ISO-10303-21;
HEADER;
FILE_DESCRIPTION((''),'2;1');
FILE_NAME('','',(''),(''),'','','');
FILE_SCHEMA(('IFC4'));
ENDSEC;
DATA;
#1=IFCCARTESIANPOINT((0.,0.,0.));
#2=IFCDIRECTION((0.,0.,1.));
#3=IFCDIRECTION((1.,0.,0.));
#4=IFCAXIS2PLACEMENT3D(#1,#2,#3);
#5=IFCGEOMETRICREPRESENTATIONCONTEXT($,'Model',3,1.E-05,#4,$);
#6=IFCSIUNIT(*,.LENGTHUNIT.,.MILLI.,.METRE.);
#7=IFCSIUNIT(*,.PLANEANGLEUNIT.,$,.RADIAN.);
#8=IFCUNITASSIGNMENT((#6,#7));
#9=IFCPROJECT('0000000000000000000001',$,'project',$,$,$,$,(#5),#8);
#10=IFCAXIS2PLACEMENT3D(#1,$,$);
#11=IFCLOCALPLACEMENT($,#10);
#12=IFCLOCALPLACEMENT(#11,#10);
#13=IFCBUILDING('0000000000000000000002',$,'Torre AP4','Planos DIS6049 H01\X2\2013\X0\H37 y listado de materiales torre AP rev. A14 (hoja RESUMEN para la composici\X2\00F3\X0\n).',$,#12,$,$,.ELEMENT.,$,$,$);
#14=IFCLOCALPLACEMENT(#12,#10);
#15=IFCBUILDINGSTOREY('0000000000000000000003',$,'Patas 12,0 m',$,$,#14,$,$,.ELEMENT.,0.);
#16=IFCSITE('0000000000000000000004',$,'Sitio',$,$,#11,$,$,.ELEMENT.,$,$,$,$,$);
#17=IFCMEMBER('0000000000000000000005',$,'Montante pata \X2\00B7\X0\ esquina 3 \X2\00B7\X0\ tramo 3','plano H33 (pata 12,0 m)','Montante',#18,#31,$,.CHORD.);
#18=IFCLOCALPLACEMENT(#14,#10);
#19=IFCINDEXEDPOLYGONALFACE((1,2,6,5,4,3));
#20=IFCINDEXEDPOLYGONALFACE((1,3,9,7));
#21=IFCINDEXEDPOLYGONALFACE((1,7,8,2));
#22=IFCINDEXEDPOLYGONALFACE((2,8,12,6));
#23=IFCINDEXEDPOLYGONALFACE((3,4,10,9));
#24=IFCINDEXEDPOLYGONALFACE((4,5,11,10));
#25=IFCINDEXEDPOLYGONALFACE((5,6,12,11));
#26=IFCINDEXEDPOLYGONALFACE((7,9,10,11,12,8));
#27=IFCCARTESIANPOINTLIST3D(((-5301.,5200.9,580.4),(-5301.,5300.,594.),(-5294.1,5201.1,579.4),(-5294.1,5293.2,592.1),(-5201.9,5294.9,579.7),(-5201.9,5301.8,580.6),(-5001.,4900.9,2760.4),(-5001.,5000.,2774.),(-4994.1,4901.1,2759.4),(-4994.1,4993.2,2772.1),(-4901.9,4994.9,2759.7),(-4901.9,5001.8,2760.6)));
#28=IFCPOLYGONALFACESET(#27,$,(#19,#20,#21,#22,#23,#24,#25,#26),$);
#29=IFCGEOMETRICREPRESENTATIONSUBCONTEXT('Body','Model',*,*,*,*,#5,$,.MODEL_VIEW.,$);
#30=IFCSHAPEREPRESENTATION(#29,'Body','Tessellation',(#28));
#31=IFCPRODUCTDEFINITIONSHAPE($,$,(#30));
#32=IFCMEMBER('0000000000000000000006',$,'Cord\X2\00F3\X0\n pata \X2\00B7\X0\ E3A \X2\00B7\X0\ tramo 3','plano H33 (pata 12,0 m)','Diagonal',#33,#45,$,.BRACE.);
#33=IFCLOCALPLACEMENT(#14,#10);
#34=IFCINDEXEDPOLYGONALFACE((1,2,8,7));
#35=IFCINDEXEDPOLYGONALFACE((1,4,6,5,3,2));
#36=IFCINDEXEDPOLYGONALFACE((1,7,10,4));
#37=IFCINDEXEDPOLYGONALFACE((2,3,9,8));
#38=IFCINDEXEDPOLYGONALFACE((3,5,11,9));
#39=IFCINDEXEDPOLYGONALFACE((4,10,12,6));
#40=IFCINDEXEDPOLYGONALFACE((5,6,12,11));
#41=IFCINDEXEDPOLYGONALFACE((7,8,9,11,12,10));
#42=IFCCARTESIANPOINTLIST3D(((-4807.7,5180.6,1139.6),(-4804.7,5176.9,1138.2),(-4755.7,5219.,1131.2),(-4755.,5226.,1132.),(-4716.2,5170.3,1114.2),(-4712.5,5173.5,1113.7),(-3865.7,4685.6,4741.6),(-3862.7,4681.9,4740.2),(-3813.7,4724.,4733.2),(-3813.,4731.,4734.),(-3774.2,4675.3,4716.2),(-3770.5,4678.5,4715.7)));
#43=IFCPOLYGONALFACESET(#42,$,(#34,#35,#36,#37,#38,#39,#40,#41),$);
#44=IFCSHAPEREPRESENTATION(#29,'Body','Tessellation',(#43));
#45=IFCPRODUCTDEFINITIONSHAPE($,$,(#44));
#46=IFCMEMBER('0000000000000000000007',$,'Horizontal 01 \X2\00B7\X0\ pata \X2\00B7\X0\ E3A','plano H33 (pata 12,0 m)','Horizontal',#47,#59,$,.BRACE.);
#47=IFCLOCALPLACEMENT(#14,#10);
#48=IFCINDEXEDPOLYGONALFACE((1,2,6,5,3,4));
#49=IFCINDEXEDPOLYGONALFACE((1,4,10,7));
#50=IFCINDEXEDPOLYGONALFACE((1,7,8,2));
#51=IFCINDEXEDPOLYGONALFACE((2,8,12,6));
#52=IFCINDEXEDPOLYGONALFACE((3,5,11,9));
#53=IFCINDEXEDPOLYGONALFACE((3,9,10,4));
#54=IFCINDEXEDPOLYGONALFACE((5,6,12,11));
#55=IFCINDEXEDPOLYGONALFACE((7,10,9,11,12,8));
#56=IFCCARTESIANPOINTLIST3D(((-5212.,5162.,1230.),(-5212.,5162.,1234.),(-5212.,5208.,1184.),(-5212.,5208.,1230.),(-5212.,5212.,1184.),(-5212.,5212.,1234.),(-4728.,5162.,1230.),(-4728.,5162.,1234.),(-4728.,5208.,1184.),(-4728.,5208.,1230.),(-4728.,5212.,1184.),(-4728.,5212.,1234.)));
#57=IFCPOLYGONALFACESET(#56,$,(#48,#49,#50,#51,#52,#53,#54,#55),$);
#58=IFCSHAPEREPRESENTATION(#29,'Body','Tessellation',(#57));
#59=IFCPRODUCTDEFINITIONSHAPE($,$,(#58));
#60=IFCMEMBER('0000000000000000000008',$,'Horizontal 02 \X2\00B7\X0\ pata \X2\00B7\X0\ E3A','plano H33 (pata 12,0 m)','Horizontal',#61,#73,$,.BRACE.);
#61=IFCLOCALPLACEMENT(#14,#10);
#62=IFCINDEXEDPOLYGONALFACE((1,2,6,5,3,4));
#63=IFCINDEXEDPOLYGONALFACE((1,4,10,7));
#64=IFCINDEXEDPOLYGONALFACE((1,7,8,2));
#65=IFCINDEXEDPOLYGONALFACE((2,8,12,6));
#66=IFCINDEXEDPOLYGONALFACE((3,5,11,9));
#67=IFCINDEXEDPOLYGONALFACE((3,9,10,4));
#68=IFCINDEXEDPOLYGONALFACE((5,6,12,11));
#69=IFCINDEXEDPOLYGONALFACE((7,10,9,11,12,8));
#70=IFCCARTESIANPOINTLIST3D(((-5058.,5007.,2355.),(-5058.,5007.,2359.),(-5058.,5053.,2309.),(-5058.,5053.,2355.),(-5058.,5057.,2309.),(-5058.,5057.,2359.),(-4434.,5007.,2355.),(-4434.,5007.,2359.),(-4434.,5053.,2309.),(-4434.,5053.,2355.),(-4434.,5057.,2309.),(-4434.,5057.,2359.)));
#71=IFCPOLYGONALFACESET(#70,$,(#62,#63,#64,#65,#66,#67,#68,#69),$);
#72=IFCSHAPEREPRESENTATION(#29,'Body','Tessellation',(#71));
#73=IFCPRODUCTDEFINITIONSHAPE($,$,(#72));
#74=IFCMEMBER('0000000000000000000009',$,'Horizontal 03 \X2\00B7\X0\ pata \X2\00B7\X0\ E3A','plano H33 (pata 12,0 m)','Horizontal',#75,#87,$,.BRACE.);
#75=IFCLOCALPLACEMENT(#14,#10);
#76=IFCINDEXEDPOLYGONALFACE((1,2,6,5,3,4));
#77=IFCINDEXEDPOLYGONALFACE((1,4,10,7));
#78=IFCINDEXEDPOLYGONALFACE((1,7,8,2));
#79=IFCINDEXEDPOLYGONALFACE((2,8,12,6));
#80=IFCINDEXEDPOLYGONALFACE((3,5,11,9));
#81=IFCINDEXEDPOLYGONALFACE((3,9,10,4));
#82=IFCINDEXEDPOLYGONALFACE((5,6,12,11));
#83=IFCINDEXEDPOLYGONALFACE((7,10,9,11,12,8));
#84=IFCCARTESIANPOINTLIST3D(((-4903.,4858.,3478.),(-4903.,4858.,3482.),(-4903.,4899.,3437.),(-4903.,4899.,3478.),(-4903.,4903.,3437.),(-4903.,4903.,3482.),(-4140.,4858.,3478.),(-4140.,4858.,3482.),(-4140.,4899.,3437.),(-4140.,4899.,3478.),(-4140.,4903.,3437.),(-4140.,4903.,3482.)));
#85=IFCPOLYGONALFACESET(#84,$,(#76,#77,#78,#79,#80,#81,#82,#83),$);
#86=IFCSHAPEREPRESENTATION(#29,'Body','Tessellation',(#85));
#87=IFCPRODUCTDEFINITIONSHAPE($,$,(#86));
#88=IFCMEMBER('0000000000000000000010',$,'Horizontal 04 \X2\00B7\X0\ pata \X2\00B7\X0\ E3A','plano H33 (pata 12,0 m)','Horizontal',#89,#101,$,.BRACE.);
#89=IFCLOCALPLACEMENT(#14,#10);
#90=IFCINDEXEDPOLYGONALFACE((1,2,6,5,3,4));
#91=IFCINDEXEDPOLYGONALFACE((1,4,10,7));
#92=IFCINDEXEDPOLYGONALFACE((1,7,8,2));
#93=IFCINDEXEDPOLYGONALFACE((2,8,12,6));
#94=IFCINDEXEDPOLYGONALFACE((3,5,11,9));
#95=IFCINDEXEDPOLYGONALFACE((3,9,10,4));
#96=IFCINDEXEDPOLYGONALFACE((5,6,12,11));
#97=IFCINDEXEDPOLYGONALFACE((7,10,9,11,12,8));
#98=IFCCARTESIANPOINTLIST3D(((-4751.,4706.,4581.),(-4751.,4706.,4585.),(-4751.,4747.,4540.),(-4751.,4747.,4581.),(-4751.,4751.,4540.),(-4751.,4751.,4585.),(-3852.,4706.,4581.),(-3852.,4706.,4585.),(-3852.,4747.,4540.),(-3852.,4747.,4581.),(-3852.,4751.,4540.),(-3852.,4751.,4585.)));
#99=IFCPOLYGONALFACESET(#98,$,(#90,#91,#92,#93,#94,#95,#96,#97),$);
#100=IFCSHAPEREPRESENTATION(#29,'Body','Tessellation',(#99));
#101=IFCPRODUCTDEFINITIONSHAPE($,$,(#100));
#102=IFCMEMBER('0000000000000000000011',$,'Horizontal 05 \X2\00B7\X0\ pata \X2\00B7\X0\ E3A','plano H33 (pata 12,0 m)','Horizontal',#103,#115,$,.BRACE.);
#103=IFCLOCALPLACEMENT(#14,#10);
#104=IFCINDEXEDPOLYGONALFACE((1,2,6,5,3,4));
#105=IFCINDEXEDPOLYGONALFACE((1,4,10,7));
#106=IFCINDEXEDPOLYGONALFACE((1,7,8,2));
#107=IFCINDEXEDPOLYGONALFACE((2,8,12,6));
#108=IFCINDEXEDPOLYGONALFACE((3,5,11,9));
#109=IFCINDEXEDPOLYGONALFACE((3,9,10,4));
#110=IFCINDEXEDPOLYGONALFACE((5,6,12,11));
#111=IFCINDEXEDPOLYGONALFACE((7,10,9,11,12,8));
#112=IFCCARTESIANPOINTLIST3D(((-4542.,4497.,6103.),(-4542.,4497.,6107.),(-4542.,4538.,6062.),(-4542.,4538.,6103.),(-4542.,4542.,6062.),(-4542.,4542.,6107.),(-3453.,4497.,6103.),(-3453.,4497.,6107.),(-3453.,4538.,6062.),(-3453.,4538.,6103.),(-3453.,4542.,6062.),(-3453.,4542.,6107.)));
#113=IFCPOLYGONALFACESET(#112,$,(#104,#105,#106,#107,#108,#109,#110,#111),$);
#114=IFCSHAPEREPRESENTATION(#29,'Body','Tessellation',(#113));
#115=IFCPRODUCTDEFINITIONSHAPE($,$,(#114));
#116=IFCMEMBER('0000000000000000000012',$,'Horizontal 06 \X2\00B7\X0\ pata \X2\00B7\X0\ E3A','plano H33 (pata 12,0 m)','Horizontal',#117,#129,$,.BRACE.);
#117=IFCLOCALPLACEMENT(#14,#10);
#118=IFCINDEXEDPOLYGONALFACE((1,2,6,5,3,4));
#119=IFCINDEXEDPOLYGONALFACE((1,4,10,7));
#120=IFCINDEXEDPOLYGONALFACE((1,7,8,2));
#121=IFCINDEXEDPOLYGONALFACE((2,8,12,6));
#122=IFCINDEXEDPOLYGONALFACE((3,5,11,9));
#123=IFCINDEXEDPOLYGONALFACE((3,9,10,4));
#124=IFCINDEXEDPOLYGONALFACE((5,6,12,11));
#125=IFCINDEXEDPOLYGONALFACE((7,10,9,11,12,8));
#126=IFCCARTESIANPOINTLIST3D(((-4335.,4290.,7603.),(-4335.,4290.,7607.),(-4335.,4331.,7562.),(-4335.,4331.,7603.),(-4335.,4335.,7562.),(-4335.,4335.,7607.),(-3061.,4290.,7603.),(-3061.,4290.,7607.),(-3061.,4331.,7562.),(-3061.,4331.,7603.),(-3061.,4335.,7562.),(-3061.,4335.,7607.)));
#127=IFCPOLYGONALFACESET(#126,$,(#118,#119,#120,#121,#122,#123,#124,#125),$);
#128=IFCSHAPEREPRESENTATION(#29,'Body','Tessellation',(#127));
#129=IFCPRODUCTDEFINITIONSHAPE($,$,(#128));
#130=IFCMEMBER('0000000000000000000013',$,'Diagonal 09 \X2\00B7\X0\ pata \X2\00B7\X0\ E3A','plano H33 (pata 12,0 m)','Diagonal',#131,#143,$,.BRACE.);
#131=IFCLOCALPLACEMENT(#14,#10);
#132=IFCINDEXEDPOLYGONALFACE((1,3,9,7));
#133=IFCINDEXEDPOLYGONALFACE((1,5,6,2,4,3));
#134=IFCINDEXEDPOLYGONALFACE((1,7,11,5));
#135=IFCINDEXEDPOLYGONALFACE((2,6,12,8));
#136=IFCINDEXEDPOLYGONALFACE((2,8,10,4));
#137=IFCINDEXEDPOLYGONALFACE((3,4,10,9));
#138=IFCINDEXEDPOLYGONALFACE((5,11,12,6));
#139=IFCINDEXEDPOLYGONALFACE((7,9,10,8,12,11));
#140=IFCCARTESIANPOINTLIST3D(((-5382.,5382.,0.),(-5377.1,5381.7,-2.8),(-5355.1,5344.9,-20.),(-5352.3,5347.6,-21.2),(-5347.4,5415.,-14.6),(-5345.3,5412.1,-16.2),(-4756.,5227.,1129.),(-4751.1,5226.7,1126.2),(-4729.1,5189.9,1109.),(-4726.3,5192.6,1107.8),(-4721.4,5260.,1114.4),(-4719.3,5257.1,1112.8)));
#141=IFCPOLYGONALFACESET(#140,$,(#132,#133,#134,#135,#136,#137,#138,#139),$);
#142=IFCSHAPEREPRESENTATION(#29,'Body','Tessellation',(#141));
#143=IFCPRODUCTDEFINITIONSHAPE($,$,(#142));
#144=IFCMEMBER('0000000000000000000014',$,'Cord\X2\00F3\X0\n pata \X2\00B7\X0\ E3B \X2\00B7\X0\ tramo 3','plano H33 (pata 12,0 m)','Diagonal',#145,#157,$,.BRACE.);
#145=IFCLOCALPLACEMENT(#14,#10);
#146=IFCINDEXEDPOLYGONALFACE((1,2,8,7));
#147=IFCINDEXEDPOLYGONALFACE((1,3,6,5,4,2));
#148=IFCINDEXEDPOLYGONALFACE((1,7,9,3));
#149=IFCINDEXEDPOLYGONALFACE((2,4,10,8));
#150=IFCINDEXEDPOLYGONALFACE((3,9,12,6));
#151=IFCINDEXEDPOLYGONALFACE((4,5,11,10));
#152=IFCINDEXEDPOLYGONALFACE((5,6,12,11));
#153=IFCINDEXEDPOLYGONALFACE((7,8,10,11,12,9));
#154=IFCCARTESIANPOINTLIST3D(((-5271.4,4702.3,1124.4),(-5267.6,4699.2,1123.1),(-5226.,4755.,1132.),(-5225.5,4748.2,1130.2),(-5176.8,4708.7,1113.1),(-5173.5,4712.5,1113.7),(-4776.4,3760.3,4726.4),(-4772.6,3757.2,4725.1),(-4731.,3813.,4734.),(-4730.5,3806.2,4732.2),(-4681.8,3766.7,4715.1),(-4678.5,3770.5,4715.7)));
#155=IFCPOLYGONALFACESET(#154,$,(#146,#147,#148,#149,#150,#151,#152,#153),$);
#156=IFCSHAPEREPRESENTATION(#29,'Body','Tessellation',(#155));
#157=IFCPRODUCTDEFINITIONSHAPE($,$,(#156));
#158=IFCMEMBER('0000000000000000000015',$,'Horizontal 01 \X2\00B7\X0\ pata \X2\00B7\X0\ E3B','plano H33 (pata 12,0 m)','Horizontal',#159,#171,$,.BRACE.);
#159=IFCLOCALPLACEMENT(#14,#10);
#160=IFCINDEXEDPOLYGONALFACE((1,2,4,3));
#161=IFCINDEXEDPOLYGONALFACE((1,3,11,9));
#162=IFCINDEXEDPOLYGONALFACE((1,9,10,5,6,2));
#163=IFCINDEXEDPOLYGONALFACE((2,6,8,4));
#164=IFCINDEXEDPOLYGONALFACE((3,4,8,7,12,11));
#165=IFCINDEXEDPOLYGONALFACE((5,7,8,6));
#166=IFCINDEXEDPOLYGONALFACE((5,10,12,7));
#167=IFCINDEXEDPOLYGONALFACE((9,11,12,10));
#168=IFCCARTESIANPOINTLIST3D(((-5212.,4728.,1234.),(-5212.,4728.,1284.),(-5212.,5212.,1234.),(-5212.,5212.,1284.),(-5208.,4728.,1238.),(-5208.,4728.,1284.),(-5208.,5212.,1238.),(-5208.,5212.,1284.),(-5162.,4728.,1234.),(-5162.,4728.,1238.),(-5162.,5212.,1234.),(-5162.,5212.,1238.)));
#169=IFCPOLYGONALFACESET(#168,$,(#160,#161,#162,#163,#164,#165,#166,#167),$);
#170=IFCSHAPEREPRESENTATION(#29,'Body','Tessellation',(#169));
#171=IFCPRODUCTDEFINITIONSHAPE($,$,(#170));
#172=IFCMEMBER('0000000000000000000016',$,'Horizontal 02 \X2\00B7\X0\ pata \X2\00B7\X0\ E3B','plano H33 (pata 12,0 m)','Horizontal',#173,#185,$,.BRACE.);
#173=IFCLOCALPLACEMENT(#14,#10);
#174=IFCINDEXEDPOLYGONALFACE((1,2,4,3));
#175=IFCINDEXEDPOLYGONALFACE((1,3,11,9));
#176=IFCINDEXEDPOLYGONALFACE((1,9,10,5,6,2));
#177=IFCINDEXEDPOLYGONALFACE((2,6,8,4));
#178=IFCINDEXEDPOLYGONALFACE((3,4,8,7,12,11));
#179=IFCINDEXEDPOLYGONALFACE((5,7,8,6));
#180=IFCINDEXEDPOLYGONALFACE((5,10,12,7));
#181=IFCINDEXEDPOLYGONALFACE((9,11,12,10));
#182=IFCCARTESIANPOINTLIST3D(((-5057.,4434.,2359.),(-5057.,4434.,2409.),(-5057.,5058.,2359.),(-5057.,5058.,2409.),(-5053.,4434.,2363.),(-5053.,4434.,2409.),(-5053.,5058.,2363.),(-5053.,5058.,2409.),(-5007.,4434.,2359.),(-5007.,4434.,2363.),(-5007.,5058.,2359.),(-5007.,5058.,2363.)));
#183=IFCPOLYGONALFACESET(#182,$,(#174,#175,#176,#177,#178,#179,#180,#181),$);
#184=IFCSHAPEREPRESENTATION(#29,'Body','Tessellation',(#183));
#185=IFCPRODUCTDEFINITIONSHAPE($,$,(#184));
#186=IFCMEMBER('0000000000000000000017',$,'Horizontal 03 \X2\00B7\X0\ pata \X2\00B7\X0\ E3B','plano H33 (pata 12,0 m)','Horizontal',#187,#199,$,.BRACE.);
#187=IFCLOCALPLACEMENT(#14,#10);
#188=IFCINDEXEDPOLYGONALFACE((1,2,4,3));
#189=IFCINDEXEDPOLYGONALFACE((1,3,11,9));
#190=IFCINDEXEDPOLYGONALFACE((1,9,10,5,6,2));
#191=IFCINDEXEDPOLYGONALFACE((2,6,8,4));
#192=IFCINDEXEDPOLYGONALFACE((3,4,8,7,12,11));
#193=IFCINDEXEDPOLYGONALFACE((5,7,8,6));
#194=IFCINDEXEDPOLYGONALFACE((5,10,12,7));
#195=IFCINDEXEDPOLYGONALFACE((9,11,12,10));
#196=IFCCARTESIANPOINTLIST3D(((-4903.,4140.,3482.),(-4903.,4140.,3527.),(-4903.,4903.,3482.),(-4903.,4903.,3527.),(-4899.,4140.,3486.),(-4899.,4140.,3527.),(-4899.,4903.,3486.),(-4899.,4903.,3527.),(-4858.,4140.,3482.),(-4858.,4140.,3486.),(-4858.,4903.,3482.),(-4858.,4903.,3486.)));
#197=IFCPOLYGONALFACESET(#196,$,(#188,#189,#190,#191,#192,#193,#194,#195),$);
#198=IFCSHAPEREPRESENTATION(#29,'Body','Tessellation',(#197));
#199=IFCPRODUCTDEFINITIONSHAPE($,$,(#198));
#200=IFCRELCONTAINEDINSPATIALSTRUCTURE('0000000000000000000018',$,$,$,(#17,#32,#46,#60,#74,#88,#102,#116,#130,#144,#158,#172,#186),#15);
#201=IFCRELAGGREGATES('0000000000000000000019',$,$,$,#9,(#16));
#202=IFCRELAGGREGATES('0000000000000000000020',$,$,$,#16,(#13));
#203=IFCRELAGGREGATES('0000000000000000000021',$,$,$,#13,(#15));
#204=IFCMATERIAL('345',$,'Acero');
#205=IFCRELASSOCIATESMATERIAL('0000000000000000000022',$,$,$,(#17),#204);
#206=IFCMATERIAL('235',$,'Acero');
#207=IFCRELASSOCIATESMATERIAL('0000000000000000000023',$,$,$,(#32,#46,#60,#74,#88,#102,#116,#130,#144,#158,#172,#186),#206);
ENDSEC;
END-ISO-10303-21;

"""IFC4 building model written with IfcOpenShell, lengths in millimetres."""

from ifc_helpers import new_model, si_unit, frame, frame_2d, origin, origin_with_axes, place, context, subcontext, project, spatial, l_section, extrude, material, element, save


model = new_model("IFC4")

# Units and contexts
model_context = context("Model", 3, precision=1e-05, world=origin_with_axes())
body_context = subcontext(model_context, "Body", "Model", "MODEL_VIEW")
ifc_project = project(units=[si_unit("LENGTHUNIT", "METRE", prefix="MILLI"), si_unit("PLANEANGLEUNIT", "RADIAN")], contexts=[model_context])

# Site, building, storey
site_placement = place(None, origin())
site = spatial("IfcSite", under=ifc_project, at=site_placement, Name="Sitio", CompositionType="ELEMENT")
building_placement = place(site_placement, origin())
building = spatial("IfcBuilding", under=site, at=building_placement, Name="Torre AP4", Description="Planos DIS6049 H01–H37 y listado de materiales torre AP rev. A14 (hoja RESUMEN para la composición).", CompositionType="ELEMENT")
storey_placement = place(building_placement, origin())
storey = spatial("IfcBuildingStorey", under=building, at=storey_placement, Name="Patas 12,0 m", CompositionType="ELEMENT", Elevation=0.0)

# Members
ifc_material_1 = material(Name="345", Category="Acero")
member_1_placement = place(storey_placement, frame((-5001.0, 5000.0, 2774.0), z_axis=(-0.13508, 0.13508, -0.981584), x_axis=(0.990835, 0.018415, -0.133819)))
element("IfcMember", 1, at=member_1_placement, inside=storey, material=ifc_material_1, Name="Montante pata · esquina 3 · tramo 3", Description="plano H33 (pata 12,0 m)", ObjectType="Montante", PredefinedType="CHORD", context=body_context, shape_type="SweptSolid", body=[
    extrude(l_section(Depth=100.0, Width=100.0, Thickness=7.0, at=frame_2d((50.0, 50.0))), None, (0.0, 0.0, 1.0), 2220.9),
])
ifc_material_2 = material(Name="235", Category="Acero")
member_2_placement = place(storey_placement, frame((-3813.0, 4731.0, 4734.0), z_axis=(-0.250805, 0.131793, -0.959024), x_axis=(0.607646, -0.749767, -0.261948)))
element("IfcMember", 2, at=member_2_placement, inside=storey, material=ifc_material_2, Name="Cordón pata · E3A · tramo 3", Description="plano H33 (pata 12,0 m)", ObjectType="Diagonal", PredefinedType="BRACE", context=body_context, shape_type="SweptSolid", body=[
    extrude(l_section(Depth=70.0, Width=70.0, Thickness=5.0, at=frame_2d((35.0, 35.0))), None, (0.0, 0.0, 1.0), 3755.9),
])
member_3_placement = place(storey_placement, frame((-5212.0, 5212.0, 1234.0), z_axis=(1.0, 0.0, 0.0), x_axis=(0.0, -1.0, 0.0)))
element("IfcMember", 3, at=member_3_placement, inside=storey, material=ifc_material_2, Name="Horizontal 01 · pata · E3A", Description="plano H33 (pata 12,0 m)", ObjectType="Horizontal", PredefinedType="BRACE", context=body_context, shape_type="SweptSolid", body=[
    extrude(l_section(Depth=50.0, Width=50.0, Thickness=4.0, at=frame_2d((25.0, 25.0))), None, (0.0, 0.0, 1.0), 484.0),
])
member_4_placement = place(storey_placement, frame((-5058.0, 5057.0, 2359.0), z_axis=(1.0, 0.0, 0.0), x_axis=(0.0, -1.0, 0.0)))
element("IfcMember", 4, at=member_4_placement, inside=storey, material=ifc_material_2, Name="Horizontal 02 · pata · E3A", Description="plano H33 (pata 12,0 m)", ObjectType="Horizontal", PredefinedType="BRACE", context=body_context, shape_type="SweptSolid", body=[
    extrude(l_section(Depth=50.0, Width=50.0, Thickness=4.0, at=frame_2d((25.0, 25.0))), None, (0.0, 0.0, 1.0), 624.0),
])
member_5_placement = place(storey_placement, frame((-4903.0, 4903.0, 3482.0), z_axis=(1.0, 0.0, 0.0), x_axis=(0.0, -1.0, 0.0)))
element("IfcMember", 5, at=member_5_placement, inside=storey, material=ifc_material_2, Name="Horizontal 03 · pata · E3A", Description="plano H33 (pata 12,0 m)", ObjectType="Horizontal", PredefinedType="BRACE", context=body_context, shape_type="SweptSolid", body=[
    extrude(l_section(Depth=45.0, Width=45.0, Thickness=4.0, at=frame_2d((22.5, 22.5))), None, (0.0, 0.0, 1.0), 763.0),
])
member_6_placement = place(storey_placement, frame((-4751.0, 4751.0, 4585.0), z_axis=(1.0, 0.0, 0.0), x_axis=(0.0, -1.0, 0.0)))
element("IfcMember", 6, at=member_6_placement, inside=storey, material=ifc_material_2, Name="Horizontal 04 · pata · E3A", Description="plano H33 (pata 12,0 m)", ObjectType="Horizontal", PredefinedType="BRACE", context=body_context, shape_type="SweptSolid", body=[
    extrude(l_section(Depth=45.0, Width=45.0, Thickness=4.0, at=frame_2d((22.5, 22.5))), None, (0.0, 0.0, 1.0), 899.0),
])
member_7_placement = place(storey_placement, frame((-4542.0, 4542.0, 6107.0), z_axis=(1.0, 0.0, 0.0), x_axis=(0.0, -1.0, 0.0)))
element("IfcMember", 7, at=member_7_placement, inside=storey, material=ifc_material_2, Name="Horizontal 05 · pata · E3A", Description="plano H33 (pata 12,0 m)", ObjectType="Horizontal", PredefinedType="BRACE", context=body_context, shape_type="SweptSolid", body=[
    extrude(l_section(Depth=45.0, Width=45.0, Thickness=4.0, at=frame_2d((22.5, 22.5))), None, (0.0, 0.0, 1.0), 1089.0),
])
member_8_placement = place(storey_placement, frame((-4335.0, 4335.0, 7607.0), z_axis=(1.0, 0.0, 0.0), x_axis=(0.0, -1.0, 0.0)))
element("IfcMember", 8, at=member_8_placement, inside=storey, material=ifc_material_2, Name="Horizontal 06 · pata · E3A", Description="plano H33 (pata 12,0 m)", ObjectType="Horizontal", PredefinedType="BRACE", context=body_context, shape_type="SweptSolid", body=[
    extrude(l_section(Depth=45.0, Width=45.0, Thickness=4.0, at=frame_2d((22.5, 22.5))), None, (0.0, 0.0, 1.0), 1274.0),
])
member_9_placement = place(storey_placement, frame((-5382.0, 5382.0, 0.0), z_axis=(0.481461, -0.119212, 0.868322), x_axis=(0.53876, -0.741182, -0.400484)))
element("IfcMember", 9, at=member_9_placement, inside=storey, material=ifc_material_2, Name="Diagonal 09 · pata · E3A", Description="plano H33 (pata 12,0 m)", ObjectType="Diagonal", PredefinedType="BRACE", context=body_context, shape_type="SweptSolid", body=[
    extrude(l_section(Depth=50.0, Width=50.0, Thickness=4.0, at=frame_2d((25.0, 25.0))), None, (0.0, 0.0, 1.0), 1300.2),
])
member_10_placement = place(storey_placement, frame((-4731.0, 3813.0, 4734.0), z_axis=(-0.131793, 0.250805, -0.959024), x_axis=(0.749767, -0.607646, -0.261948)))
element("IfcMember", 10, at=member_10_placement, inside=storey, material=ifc_material_2, Name="Cordón pata · E3B · tramo 3", Description="plano H33 (pata 12,0 m)", ObjectType="Diagonal", PredefinedType="BRACE", context=body_context, shape_type="SweptSolid", body=[
    extrude(l_section(Depth=70.0, Width=70.0, Thickness=5.0, at=frame_2d((35.0, 35.0))), None, (0.0, 0.0, 1.0), 3755.9),
])
member_11_placement = place(storey_placement, frame((-5212.0, 5212.0, 1234.0), z_axis=(0.0, -1.0, 0.0), x_axis=(1.0, 0.0, 0.0)))
element("IfcMember", 11, at=member_11_placement, inside=storey, material=ifc_material_2, Name="Horizontal 01 · pata · E3B", Description="plano H33 (pata 12,0 m)", ObjectType="Horizontal", PredefinedType="BRACE", context=body_context, shape_type="SweptSolid", body=[
    extrude(l_section(Depth=50.0, Width=50.0, Thickness=4.0, at=frame_2d((25.0, 25.0))), None, (0.0, 0.0, 1.0), 484.0),
])
member_12_placement = place(storey_placement, frame((-5057.0, 5058.0, 2359.0), z_axis=(0.0, -1.0, 0.0), x_axis=(1.0, 0.0, 0.0)))
element("IfcMember", 12, at=member_12_placement, inside=storey, material=ifc_material_2, Name="Horizontal 02 · pata · E3B", Description="plano H33 (pata 12,0 m)", ObjectType="Horizontal", PredefinedType="BRACE", context=body_context, shape_type="SweptSolid", body=[
    extrude(l_section(Depth=50.0, Width=50.0, Thickness=4.0, at=frame_2d((25.0, 25.0))), None, (0.0, 0.0, 1.0), 624.0),
])
member_13_placement = place(storey_placement, frame((-4903.0, 4903.0, 3482.0), z_axis=(0.0, -1.0, 0.0), x_axis=(1.0, 0.0, 0.0)))
element("IfcMember", 13, at=member_13_placement, inside=storey, material=ifc_material_2, Name="Horizontal 03 · pata · E3B", Description="plano H33 (pata 12,0 m)", ObjectType="Horizontal", PredefinedType="BRACE", context=body_context, shape_type="SweptSolid", body=[
    extrude(l_section(Depth=45.0, Width=45.0, Thickness=4.0, at=frame_2d((22.5, 22.5))), None, (0.0, 0.0, 1.0), 763.0),
])

save(model, "model.ifc")
